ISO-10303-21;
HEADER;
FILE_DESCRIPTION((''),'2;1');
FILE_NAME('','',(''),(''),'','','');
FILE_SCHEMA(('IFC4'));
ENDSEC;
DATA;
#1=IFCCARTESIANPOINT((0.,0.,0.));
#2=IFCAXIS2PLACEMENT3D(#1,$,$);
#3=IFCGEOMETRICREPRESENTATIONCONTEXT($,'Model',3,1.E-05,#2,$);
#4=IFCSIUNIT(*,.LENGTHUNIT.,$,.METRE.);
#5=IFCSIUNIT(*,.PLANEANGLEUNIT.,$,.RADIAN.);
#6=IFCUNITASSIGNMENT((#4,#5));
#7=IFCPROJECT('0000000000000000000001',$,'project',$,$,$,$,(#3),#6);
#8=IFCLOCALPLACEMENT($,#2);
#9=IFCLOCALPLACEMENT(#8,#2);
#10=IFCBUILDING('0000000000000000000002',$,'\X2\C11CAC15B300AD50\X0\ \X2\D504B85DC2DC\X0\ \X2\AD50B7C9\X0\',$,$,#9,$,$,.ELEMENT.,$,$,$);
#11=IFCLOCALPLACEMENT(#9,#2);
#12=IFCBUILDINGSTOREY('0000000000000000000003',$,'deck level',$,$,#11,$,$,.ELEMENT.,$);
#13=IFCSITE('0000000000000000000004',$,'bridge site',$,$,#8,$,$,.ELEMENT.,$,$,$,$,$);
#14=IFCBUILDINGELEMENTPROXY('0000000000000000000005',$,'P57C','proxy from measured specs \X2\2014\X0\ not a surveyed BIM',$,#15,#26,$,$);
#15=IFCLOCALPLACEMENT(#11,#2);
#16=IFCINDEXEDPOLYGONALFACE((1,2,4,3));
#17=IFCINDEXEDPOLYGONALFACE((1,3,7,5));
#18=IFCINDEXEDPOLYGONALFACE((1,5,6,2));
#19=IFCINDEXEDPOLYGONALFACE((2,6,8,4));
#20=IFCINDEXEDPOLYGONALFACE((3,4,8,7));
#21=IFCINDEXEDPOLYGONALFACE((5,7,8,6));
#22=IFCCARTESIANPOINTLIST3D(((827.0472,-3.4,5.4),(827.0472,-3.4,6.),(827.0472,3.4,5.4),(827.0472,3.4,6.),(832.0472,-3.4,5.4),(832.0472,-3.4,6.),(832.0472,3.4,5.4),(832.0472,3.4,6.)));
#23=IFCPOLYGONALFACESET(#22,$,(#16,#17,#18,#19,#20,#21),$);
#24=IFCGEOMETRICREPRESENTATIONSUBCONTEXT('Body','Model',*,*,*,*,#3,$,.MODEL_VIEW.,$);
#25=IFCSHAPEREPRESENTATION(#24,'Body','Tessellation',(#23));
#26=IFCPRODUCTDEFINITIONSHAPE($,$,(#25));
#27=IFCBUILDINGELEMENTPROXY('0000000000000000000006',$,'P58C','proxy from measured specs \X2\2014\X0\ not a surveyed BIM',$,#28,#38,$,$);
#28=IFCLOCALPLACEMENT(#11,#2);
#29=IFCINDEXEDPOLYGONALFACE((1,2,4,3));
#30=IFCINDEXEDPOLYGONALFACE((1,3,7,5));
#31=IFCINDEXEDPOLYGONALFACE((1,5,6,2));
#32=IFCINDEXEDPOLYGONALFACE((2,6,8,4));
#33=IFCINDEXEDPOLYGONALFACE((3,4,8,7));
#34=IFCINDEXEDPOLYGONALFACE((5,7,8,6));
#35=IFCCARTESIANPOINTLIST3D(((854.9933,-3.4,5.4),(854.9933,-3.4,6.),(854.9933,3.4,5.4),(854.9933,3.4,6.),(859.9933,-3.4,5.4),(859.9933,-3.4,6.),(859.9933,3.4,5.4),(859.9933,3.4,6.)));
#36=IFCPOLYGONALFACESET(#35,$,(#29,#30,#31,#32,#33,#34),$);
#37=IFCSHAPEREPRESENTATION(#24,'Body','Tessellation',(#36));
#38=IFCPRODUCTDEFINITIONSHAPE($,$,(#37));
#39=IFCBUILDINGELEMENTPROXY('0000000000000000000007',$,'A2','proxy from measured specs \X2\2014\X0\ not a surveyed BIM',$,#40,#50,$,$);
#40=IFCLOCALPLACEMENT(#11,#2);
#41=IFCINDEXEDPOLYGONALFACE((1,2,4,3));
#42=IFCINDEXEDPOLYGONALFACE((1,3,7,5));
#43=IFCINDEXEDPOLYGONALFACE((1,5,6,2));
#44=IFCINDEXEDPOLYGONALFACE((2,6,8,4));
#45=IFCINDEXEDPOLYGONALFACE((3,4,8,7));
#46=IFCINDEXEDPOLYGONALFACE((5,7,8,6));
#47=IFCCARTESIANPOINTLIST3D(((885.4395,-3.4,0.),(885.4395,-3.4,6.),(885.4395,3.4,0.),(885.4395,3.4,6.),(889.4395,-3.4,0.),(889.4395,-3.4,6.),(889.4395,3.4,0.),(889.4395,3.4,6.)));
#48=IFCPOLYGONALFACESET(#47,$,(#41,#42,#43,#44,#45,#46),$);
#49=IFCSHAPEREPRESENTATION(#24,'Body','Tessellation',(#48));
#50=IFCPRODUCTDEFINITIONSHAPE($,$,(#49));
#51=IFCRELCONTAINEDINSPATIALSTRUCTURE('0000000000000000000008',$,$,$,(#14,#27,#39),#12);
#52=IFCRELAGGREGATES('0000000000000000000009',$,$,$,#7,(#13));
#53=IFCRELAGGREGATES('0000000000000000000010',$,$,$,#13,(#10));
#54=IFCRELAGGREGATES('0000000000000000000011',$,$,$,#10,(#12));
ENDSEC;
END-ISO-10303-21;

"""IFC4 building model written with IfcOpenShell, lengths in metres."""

from ifc_helpers import new_model, si_unit, frame, origin, origin_2d, place, context, subcontext, project, spatial, rectangle, extrude, element, save


model = new_model("IFC4")

# Units and contexts
model_context = context("Model", 3, precision=1e-05, world=origin())
body_context = subcontext(model_context, "Body", "Model", "MODEL_VIEW")
ifc_project = project(units=[si_unit("LENGTHUNIT", "METRE"), si_unit("PLANEANGLEUNIT", "RADIAN")], contexts=[model_context])

# Site, building, storey
site_placement = place(None, origin())
site = spatial("IfcSite", under=ifc_project, at=site_placement, Name="bridge site", CompositionType="ELEMENT")
building_placement = place(site_placement, origin())
building = spatial("IfcBuilding", under=site, at=building_placement, Name="서강대교 프록시 교량", CompositionType="ELEMENT")
storey_placement = place(building_placement, origin())
storey = spatial("IfcBuildingStorey", under=building, at=storey_placement, Name="deck level", CompositionType="ELEMENT")

# Building element proxies
for number, where, name in (
    (1, (829.5472, 0.0, 5.4), "P57C"),
    (2, (857.4933, 0.0, 5.4), "P58C"),
):
    element("IfcBuildingElementProxy", number, at=place(storey_placement, frame(where)), inside=storey, Name=name, Description="proxy from measured specs — not a surveyed BIM", context=body_context, shape_type="SweptSolid", body=[
        extrude(rectangle(XDim=5.0, YDim=6.8, at=origin_2d()), origin(), (0.0, 0.0, 1.0), 0.6),
    ])
proxy_placement = place(storey_placement, frame((887.4395, 0.0, 0.0)))
element("IfcBuildingElementProxy", 3, at=proxy_placement, inside=storey, Name="A2", Description="proxy from measured specs — not a surveyed BIM", context=body_context, shape_type="SweptSolid", body=[
    extrude(rectangle(XDim=4.0, YDim=6.8, at=origin_2d()), origin(), (0.0, 0.0, 1.0), 6.0),
])

save(model, "model.ifc")
